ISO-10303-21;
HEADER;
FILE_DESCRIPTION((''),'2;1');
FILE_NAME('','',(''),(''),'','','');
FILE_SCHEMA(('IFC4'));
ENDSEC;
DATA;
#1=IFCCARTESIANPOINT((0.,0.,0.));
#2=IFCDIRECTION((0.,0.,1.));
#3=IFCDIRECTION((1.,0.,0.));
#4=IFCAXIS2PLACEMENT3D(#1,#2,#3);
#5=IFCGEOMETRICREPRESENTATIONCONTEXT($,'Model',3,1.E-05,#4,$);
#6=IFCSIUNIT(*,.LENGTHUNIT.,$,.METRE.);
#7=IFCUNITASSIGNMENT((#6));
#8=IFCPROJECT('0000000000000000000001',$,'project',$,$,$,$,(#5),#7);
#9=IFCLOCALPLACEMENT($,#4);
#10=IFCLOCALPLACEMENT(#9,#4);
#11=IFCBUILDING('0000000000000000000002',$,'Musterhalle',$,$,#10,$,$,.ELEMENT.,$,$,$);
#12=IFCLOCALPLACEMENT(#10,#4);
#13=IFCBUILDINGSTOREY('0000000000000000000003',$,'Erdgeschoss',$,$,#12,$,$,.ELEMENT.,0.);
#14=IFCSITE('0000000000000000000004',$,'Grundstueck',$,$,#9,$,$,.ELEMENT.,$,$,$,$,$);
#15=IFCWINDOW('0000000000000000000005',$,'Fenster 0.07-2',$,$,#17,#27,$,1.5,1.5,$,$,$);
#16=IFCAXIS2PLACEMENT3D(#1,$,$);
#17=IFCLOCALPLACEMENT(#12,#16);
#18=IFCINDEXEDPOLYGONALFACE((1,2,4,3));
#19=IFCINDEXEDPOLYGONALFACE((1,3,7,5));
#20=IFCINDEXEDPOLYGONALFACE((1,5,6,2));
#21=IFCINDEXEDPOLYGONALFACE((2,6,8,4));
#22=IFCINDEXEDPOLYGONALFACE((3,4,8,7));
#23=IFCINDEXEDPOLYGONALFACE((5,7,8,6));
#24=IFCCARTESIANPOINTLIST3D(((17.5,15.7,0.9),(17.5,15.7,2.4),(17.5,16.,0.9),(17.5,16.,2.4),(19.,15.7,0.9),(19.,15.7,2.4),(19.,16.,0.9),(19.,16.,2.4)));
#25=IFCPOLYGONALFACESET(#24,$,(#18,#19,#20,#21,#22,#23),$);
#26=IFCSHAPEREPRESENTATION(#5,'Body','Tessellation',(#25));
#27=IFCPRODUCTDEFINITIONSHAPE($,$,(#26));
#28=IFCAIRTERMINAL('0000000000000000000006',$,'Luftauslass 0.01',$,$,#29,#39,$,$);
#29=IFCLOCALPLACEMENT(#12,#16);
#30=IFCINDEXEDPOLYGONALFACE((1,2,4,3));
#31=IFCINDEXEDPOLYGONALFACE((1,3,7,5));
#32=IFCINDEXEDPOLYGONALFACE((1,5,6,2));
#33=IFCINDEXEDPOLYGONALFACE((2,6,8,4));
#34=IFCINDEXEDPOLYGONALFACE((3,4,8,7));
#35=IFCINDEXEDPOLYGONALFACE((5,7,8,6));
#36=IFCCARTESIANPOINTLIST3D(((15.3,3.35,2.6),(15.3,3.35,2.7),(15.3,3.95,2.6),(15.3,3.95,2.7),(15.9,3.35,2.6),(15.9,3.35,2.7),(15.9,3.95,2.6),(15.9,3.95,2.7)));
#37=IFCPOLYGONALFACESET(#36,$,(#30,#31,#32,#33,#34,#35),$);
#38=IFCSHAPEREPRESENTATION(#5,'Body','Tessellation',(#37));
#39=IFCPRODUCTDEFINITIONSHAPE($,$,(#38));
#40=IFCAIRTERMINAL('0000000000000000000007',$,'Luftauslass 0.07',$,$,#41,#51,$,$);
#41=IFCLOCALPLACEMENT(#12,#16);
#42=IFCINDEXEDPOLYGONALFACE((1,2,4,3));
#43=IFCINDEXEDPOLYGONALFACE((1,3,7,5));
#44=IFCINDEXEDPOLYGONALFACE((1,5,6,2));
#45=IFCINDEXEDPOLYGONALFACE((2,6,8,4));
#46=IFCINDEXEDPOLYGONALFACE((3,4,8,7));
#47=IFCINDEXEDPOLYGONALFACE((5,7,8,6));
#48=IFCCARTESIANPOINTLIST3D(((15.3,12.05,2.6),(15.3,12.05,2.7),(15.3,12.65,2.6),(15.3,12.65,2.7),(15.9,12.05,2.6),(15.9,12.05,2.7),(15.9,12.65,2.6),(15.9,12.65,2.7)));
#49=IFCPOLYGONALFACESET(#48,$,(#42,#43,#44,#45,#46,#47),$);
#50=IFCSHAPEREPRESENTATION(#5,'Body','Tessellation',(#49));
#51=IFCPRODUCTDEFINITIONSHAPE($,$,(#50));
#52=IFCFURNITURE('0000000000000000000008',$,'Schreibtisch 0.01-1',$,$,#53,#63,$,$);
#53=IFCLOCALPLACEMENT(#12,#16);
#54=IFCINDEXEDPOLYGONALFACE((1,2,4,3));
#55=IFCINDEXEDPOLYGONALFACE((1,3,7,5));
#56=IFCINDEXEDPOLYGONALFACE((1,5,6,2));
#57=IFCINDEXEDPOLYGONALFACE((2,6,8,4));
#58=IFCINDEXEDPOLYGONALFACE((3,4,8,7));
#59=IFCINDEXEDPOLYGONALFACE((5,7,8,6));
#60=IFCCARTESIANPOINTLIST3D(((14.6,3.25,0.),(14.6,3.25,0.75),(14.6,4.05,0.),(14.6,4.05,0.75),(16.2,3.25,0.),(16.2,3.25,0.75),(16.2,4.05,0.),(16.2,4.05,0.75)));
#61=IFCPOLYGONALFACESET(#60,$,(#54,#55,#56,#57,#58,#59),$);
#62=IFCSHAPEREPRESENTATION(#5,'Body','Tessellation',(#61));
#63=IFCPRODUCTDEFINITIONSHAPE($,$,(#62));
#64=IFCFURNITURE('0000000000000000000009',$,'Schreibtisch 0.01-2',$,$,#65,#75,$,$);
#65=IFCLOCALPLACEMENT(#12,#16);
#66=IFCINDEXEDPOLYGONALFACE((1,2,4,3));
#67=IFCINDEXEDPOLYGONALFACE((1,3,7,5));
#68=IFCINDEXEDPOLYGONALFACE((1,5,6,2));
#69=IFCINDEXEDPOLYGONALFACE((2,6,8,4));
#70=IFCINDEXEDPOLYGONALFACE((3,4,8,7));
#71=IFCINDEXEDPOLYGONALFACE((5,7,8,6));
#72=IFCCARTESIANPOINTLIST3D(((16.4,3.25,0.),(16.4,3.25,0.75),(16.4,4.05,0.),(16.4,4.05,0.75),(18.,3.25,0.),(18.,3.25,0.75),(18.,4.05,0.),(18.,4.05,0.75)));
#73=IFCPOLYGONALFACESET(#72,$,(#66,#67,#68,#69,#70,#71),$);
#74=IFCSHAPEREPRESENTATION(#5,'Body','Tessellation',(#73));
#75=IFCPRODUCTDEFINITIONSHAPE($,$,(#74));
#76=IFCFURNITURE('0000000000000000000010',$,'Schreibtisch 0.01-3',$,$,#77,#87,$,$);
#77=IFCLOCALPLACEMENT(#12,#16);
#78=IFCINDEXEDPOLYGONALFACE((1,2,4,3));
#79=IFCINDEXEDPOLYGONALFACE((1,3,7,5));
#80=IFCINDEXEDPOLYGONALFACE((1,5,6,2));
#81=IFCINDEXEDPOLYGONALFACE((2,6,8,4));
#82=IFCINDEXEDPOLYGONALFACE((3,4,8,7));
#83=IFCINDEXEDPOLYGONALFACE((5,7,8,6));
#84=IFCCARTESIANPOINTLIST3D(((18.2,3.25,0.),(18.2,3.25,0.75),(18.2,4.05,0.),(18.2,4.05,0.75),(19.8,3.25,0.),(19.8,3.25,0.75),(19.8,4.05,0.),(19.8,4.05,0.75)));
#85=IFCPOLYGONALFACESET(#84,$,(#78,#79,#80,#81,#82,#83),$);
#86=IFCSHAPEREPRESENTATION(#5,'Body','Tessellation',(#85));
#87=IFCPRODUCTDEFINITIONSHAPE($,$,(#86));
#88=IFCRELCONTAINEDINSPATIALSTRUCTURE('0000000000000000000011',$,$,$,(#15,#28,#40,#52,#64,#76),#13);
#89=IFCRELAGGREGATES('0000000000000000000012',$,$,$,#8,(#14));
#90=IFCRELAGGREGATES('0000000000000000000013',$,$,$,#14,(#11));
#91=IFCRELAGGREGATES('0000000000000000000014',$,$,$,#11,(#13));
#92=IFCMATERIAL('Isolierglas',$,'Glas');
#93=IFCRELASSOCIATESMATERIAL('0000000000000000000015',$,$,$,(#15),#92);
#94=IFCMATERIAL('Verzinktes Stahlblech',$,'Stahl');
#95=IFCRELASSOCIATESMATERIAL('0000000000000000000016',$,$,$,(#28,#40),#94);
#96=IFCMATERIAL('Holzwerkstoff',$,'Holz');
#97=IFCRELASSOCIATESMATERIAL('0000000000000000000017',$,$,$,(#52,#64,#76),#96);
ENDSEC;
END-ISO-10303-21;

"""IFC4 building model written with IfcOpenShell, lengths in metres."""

from ifc_helpers import new_model, si_unit, frame, origin_with_axes, origin_2d, place, context, project, spatial, rectangle, extrude, material, element, save


model = new_model("IFC4")

# Units and contexts
model_context = context("Model", 3, precision=1e-05, world=origin_with_axes())
ifc_project = project(units=[si_unit("LENGTHUNIT", "METRE")], contexts=[model_context])

# Site, building, storey
site_placement = place(None, origin_with_axes())
site = spatial("IfcSite", under=ifc_project, at=site_placement, Name="Grundstueck", CompositionType="ELEMENT")
building_placement = place(site_placement, origin_with_axes())
building = spatial("IfcBuilding", under=site, at=building_placement, Name="Musterhalle", CompositionType="ELEMENT")
storey_placement = place(building_placement, origin_with_axes())
storey = spatial("IfcBuildingStorey", under=building, at=storey_placement, Name="Erdgeschoss", CompositionType="ELEMENT", Elevation=0.0)

# Shared definitions
placement = place(storey_placement, origin_with_axes())

# Shared definitions
ifc_material_1 = material(Name="Holzwerkstoff", Category="Holz")

# Shared definitions
ifc_material_2 = material(Name="Isolierglas", Category="Glas")

# Window
element("IfcWindow", 1, at=placement, inside=storey, material=ifc_material_2, Name="Fenster 0.07-2", OverallHeight=1.5, OverallWidth=1.5, context=model_context, shape_type="SweptSolid", body=[
    extrude(rectangle(XDim=1.5, YDim=0.3, at=origin_2d()), frame((18.25, 15.85, 0.9), z_axis=(0.0, 0.0, 1.0), x_axis=(1.0, 0.0, 0.0)), (0.0, 0.0, 1.0), 1.5),
])

# Air terminals
ifc_material_3 = material(Name="Verzinktes Stahlblech", Category="Stahl")
element("IfcAirTerminal", 2, at=placement, inside=storey, material=ifc_material_3, Name="Luftauslass 0.01", context=model_context, shape_type="SweptSolid", body=[
    extrude(rectangle(XDim=0.6, YDim=0.6, at=origin_2d()), frame((15.6, 3.65, 2.6), z_axis=(0.0, 0.0, 1.0), x_axis=(1.0, 0.0, 0.0)), (0.0, 0.0, 1.0), 0.1),
])
element("IfcAirTerminal", 3, at=placement, inside=storey, material=ifc_material_3, Name="Luftauslass 0.07", context=model_context, shape_type="SweptSolid", body=[
    extrude(rectangle(XDim=0.6, YDim=0.6, at=origin_2d()), frame((15.6, 12.35, 2.6), z_axis=(0.0, 0.0, 1.0), x_axis=(1.0, 0.0, 0.0)), (0.0, 0.0, 1.0), 0.1),
])

# Furniture
element("IfcFurniture", 4, at=placement, inside=storey, material=ifc_material_1, Name="Schreibtisch 0.01-1", context=model_context, shape_type="SweptSolid", body=[
    extrude(rectangle(XDim=1.6, YDim=0.8, at=origin_2d()), frame((15.4, 3.65, 0.0), z_axis=(0.0, 0.0, 1.0), x_axis=(1.0, 0.0, 0.0)), (0.0, 0.0, 1.0), 0.75),
])
element("IfcFurniture", 5, at=placement, inside=storey, material=ifc_material_1, Name="Schreibtisch 0.01-2", context=model_context, shape_type="SweptSolid", body=[
    extrude(rectangle(XDim=1.6, YDim=0.8, at=origin_2d()), frame((17.2, 3.65, 0.0), z_axis=(0.0, 0.0, 1.0), x_axis=(1.0, 0.0, 0.0)), (0.0, 0.0, 1.0), 0.75),
])
element("IfcFurniture", 6, at=placement, inside=storey, material=ifc_material_1, Name="Schreibtisch 0.01-3", context=model_context, shape_type="SweptSolid", body=[
    extrude(rectangle(XDim=1.6, YDim=0.8, at=origin_2d()), frame((19.0, 3.65, 0.0), z_axis=(0.0, 0.0, 1.0), x_axis=(1.0, 0.0, 0.0)), (0.0, 0.0, 1.0), 0.75),
])

save(model, "model.ifc")
